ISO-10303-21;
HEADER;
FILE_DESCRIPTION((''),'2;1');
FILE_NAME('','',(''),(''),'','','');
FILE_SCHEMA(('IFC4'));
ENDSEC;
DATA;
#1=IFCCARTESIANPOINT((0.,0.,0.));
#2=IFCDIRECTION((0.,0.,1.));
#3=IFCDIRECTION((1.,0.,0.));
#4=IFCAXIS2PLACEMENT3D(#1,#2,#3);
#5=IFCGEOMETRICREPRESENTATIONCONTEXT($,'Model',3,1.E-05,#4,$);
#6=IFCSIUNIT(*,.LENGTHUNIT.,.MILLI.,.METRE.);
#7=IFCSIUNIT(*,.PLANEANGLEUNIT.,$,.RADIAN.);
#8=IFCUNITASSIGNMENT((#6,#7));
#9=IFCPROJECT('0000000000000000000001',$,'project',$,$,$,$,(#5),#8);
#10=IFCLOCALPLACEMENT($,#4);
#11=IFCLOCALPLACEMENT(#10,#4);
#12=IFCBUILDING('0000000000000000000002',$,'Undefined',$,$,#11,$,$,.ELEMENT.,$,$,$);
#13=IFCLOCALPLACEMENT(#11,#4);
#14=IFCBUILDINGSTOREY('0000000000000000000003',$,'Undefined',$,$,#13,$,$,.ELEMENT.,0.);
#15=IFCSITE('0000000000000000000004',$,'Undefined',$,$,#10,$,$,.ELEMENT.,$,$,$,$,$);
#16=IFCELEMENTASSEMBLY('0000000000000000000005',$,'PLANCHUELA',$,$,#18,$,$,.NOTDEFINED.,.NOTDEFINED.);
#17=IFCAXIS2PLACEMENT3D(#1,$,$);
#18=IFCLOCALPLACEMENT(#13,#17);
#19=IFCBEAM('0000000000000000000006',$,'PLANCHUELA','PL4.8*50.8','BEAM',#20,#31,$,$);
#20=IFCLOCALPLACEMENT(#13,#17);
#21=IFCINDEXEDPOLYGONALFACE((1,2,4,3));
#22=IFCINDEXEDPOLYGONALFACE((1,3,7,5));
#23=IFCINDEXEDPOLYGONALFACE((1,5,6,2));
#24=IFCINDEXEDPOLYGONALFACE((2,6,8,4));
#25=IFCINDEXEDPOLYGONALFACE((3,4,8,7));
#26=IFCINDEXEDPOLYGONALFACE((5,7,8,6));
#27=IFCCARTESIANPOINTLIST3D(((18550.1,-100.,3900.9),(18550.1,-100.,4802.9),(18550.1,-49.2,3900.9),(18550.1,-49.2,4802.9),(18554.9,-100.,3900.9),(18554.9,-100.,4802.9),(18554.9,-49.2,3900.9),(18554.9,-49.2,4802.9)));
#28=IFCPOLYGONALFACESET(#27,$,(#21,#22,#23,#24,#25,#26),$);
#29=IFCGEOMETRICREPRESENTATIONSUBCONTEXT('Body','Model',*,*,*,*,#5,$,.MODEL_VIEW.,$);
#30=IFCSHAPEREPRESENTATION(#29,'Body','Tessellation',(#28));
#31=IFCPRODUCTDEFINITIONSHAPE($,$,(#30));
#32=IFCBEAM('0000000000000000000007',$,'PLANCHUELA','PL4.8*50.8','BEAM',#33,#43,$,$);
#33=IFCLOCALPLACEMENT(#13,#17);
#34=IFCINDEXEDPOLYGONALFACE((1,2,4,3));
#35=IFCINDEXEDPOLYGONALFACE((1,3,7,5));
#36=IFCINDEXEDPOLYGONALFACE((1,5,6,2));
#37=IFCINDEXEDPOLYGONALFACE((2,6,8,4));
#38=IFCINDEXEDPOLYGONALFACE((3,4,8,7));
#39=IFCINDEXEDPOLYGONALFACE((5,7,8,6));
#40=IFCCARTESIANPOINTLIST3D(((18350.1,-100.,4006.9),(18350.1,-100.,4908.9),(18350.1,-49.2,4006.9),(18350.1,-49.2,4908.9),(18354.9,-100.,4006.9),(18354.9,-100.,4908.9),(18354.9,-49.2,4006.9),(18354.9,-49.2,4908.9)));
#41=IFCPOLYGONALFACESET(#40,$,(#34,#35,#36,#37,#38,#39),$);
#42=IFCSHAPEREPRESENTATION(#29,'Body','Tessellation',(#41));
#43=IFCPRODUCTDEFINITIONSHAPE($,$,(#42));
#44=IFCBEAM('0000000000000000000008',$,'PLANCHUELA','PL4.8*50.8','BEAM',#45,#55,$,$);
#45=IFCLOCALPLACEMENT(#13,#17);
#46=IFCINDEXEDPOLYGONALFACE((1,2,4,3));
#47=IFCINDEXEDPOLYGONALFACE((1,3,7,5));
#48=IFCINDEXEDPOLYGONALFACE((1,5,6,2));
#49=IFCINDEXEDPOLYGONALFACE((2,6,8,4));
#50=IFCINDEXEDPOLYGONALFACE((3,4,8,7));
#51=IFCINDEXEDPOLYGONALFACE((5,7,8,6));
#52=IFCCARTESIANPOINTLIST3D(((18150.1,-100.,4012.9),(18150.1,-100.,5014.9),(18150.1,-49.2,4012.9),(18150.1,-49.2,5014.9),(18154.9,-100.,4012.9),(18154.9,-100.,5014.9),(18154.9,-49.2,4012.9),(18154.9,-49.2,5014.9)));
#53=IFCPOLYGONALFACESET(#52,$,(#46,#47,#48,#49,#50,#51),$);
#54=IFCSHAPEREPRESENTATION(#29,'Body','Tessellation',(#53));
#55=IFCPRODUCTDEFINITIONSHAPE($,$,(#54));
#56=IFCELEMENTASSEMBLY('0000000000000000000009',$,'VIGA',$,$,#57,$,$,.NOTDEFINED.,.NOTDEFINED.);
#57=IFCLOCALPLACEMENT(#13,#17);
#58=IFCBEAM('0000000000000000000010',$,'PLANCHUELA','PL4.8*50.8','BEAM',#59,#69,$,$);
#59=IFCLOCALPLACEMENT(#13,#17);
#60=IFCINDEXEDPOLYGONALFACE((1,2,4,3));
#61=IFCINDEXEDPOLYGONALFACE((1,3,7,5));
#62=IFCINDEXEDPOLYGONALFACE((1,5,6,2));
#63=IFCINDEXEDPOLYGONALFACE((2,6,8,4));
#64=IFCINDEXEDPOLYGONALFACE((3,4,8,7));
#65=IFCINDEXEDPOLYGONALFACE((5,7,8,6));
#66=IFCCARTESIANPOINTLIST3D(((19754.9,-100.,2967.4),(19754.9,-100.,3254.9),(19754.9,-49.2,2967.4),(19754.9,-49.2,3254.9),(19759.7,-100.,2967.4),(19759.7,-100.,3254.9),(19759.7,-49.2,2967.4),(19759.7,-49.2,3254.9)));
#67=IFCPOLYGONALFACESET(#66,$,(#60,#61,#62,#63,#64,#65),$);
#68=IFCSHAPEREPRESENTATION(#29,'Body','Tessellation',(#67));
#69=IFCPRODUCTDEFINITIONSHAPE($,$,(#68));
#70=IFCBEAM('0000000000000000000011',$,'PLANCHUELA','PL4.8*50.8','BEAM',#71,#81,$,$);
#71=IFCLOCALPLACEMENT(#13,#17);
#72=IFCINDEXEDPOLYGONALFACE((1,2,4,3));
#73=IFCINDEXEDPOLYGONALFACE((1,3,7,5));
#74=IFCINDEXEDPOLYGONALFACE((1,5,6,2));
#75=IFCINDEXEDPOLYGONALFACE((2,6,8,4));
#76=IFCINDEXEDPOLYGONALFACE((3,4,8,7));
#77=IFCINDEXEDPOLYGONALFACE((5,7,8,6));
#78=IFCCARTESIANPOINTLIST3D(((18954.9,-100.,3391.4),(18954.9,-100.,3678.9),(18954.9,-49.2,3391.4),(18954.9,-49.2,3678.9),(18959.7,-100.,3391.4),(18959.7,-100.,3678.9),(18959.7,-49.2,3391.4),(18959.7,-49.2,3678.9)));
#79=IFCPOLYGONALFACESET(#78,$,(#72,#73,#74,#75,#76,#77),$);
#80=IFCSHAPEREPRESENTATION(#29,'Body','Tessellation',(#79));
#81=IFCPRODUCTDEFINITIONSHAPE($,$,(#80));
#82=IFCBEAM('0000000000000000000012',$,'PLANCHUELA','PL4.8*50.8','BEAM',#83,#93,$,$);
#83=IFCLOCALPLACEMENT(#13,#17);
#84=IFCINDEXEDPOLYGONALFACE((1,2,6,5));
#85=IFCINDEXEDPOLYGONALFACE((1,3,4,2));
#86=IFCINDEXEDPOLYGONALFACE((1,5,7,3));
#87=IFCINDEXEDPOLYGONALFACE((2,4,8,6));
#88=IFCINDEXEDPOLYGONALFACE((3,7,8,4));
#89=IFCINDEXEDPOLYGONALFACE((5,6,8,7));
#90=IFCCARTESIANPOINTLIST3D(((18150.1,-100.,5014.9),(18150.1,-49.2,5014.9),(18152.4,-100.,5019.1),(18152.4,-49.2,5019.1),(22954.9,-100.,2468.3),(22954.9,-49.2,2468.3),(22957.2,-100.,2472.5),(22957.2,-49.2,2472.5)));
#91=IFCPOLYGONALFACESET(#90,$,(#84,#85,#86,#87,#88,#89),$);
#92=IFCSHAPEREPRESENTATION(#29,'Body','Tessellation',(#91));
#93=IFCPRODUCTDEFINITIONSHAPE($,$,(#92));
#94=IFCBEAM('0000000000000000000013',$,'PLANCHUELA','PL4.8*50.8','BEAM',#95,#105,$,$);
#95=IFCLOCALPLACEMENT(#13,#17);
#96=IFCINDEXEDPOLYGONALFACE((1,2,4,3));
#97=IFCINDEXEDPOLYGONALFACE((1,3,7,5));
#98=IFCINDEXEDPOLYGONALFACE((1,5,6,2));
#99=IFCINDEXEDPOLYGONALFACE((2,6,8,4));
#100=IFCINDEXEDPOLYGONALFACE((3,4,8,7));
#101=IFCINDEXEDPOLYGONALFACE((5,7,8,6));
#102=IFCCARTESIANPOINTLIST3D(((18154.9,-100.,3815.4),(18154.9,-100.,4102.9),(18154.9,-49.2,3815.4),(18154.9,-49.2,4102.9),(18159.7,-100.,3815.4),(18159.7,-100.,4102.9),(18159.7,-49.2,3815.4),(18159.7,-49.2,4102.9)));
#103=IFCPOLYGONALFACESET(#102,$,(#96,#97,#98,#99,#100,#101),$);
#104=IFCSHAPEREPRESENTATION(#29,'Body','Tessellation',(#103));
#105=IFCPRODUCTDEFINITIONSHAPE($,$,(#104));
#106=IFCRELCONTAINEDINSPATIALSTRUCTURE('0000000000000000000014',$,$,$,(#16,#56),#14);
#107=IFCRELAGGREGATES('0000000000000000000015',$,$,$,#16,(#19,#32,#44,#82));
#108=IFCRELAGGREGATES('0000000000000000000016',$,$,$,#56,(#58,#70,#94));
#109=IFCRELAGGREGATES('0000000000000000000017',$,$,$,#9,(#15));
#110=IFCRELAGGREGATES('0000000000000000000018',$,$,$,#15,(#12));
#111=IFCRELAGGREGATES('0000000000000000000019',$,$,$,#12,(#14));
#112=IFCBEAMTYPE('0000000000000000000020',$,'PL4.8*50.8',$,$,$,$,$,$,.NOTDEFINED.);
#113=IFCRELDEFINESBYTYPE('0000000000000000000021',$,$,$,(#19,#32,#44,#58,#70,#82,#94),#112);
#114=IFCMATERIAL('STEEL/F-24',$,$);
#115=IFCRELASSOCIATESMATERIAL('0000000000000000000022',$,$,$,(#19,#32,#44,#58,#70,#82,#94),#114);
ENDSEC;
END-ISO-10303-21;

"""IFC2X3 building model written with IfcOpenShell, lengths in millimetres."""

from ifc_helpers import new_model, si_unit, frame, origin_with_axes, origin_2d_with_axis, place, context, subcontext, project, spatial, rectangle, extrude, material, type_object, element, aggregate, save


model = new_model("IFC2X3")

# Units and contexts
model_context = context("Model", 3, precision=1e-05, world=origin_with_axes())
body_context = subcontext(model_context, "Body", "Model", "MODEL_VIEW")
ifc_project = project(units=[si_unit("LENGTHUNIT", "METRE", prefix="MILLI"), si_unit("PLANEANGLEUNIT", "RADIAN")], contexts=[model_context])

# Site, building, storey
site_placement = place(None, origin_with_axes())
site = spatial("IfcSite", under=ifc_project, at=site_placement, Name="Undefined", CompositionType="ELEMENT")
building_placement = place(site_placement, origin_with_axes())
building = spatial("IfcBuilding", under=site, at=building_placement, Name="Undefined", CompositionType="ELEMENT")
storey_placement = place(building_placement, origin_with_axes())
storey = spatial("IfcBuildingStorey", under=building, at=storey_placement, Name="Undefined", CompositionType="ELEMENT", Elevation=0.0)

# Element assemblies, beams
assembly_1_placement = place(storey_placement, origin_with_axes())
assembly_1 = element("IfcElementAssembly", 1, at=assembly_1_placement, inside=storey, Name="PLANCHUELA", AssemblyPlace="NOTDEFINED", PredefinedType="NOTDEFINED")
ifc_material_1 = material(Name="STEEL/F-24")
beam_type = type_object("IfcBeamType", Name="PL4.8*50.8", PredefinedType="NOTDEFINED")
beam_1_placement = place(assembly_1_placement, frame((18552.5, -74.6, 4802.9), z_axis=(0.0, 1.0, 0.0), x_axis=(0.0, 0.0, -1.0)))
beam_1 = element("IfcBeam", 2, at=beam_1_placement, type_object=beam_type, material=ifc_material_1, Name="PLANCHUELA", Description="PL4.8*50.8", ObjectType="BEAM", context=body_context, shape_type="SweptSolid", body=[
    extrude(rectangle(XDim=4.8, YDim=50.8, at=origin_2d_with_axis()), frame((902.0, 0.0, 0.0), z_axis=(-1.0, 0.0, 0.0), x_axis=(0.0, -1.0, 0.0)), (0.0, 0.0, 1.0), 902.0),
])
beam_2_placement = place(assembly_1_placement, frame((18352.5, -74.6, 4908.9), z_axis=(0.0, 1.0, 0.0), x_axis=(0.0, 0.0, -1.0)))
beam_2 = element("IfcBeam", 3, at=beam_2_placement, type_object=beam_type, material=ifc_material_1, Name="PLANCHUELA", Description="PL4.8*50.8", ObjectType="BEAM", context=body_context, shape_type="SweptSolid", body=[
    extrude(rectangle(XDim=4.8, YDim=50.8, at=origin_2d_with_axis()), frame((902.0, 0.0, 0.0), z_axis=(-1.0, 0.0, 0.0), x_axis=(0.0, -1.0, 0.0)), (0.0, 0.0, 1.0), 902.0),
])
beam_3_placement = place(assembly_1_placement, frame((18152.5, -74.6, 5014.9), z_axis=(0.0, 1.0, 0.0), x_axis=(0.0, 0.0, -1.0)))
beam_3 = element("IfcBeam", 4, at=beam_3_placement, type_object=beam_type, material=ifc_material_1, Name="PLANCHUELA", Description="PL4.8*50.8", ObjectType="BEAM", context=body_context, shape_type="SweptSolid", body=[
    extrude(rectangle(XDim=4.8, YDim=50.8, at=origin_2d_with_axis()), frame((1002.0, 0.0, 0.0), z_axis=(-1.0, 0.0, 0.0), x_axis=(0.0, -1.0, 0.0)), (0.0, 0.0, 1.0), 1002.0),
])
assembly_2_placement = place(storey_placement, origin_with_axes())
assembly_2 = element("IfcElementAssembly", 5, at=assembly_2_placement, inside=storey, Name="VIGA", AssemblyPlace="NOTDEFINED", PredefinedType="NOTDEFINED")
beam_4_placement = place(assembly_2_placement, frame((19757.3, -74.6, 3254.9), z_axis=(0.0, -1.0, 0.0), x_axis=(0.0, 0.0, -1.0)))
beam_4 = element("IfcBeam", 6, at=beam_4_placement, type_object=beam_type, material=ifc_material_1, Name="PLANCHUELA", Description="PL4.8*50.8", ObjectType="BEAM", context=body_context, shape_type="SweptSolid", body=[
    extrude(rectangle(XDim=4.8, YDim=50.8, at=origin_2d_with_axis()), frame((287.5, 0.0, 0.0), z_axis=(-1.0, 0.0, 0.0), x_axis=(0.0, -1.0, 0.0)), (0.0, 0.0, 1.0), 287.5),
])
beam_5_placement = place(assembly_2_placement, frame((18957.3, -74.6, 3678.9), z_axis=(0.0, -1.0, 0.0), x_axis=(0.0, 0.0, -1.0)))
beam_5 = element("IfcBeam", 7, at=beam_5_placement, type_object=beam_type, material=ifc_material_1, Name="PLANCHUELA", Description="PL4.8*50.8", ObjectType="BEAM", context=body_context, shape_type="SweptSolid", body=[
    extrude(rectangle(XDim=4.8, YDim=50.8, at=origin_2d_with_axis()), frame((287.5, 0.0, 0.0), z_axis=(-1.0, 0.0, 0.0), x_axis=(0.0, -1.0, 0.0)), (0.0, 0.0, 1.0), 287.5),
])

# Beams
beam_6_placement = place(assembly_1_placement, frame((18151.2, -74.6, 5017.0), z_axis=(0.0, 1.0, 0.0), x_axis=(0.883573, 0.0, -0.468294)))
beam_6 = element("IfcBeam", 8, at=beam_6_placement, type_object=beam_type, material=ifc_material_1, Name="PLANCHUELA", Description="PL4.8*50.8", ObjectType="BEAM", context=body_context, shape_type="SweptSolid", body=[
    extrude(rectangle(XDim=4.8, YDim=50.8, at=origin_2d_with_axis()), frame((5437.9, 0.0, 0.0), z_axis=(-1.0, 0.0, 0.0), x_axis=(0.0, -1.0, 0.0)), (0.0, 0.0, 1.0), 5437.9),
])
aggregate(assembly_1, [beam_1, beam_2, beam_3, beam_6])
beam_7_placement = place(assembly_2_placement, frame((18157.3, -74.6, 4102.9), z_axis=(0.0, -1.0, 0.0), x_axis=(0.0, 0.0, -1.0)))
beam_7 = element("IfcBeam", 9, at=beam_7_placement, type_object=beam_type, material=ifc_material_1, Name="PLANCHUELA", Description="PL4.8*50.8", ObjectType="BEAM", context=body_context, shape_type="SweptSolid", body=[
    extrude(rectangle(XDim=4.8, YDim=50.8, at=origin_2d_with_axis()), frame((287.5, 0.0, 0.0), z_axis=(-1.0, 0.0, 0.0), x_axis=(0.0, -1.0, 0.0)), (0.0, 0.0, 1.0), 287.5),
])

aggregate(assembly_2, [beam_4, beam_5, beam_7])

save(model, "model.ifc")
